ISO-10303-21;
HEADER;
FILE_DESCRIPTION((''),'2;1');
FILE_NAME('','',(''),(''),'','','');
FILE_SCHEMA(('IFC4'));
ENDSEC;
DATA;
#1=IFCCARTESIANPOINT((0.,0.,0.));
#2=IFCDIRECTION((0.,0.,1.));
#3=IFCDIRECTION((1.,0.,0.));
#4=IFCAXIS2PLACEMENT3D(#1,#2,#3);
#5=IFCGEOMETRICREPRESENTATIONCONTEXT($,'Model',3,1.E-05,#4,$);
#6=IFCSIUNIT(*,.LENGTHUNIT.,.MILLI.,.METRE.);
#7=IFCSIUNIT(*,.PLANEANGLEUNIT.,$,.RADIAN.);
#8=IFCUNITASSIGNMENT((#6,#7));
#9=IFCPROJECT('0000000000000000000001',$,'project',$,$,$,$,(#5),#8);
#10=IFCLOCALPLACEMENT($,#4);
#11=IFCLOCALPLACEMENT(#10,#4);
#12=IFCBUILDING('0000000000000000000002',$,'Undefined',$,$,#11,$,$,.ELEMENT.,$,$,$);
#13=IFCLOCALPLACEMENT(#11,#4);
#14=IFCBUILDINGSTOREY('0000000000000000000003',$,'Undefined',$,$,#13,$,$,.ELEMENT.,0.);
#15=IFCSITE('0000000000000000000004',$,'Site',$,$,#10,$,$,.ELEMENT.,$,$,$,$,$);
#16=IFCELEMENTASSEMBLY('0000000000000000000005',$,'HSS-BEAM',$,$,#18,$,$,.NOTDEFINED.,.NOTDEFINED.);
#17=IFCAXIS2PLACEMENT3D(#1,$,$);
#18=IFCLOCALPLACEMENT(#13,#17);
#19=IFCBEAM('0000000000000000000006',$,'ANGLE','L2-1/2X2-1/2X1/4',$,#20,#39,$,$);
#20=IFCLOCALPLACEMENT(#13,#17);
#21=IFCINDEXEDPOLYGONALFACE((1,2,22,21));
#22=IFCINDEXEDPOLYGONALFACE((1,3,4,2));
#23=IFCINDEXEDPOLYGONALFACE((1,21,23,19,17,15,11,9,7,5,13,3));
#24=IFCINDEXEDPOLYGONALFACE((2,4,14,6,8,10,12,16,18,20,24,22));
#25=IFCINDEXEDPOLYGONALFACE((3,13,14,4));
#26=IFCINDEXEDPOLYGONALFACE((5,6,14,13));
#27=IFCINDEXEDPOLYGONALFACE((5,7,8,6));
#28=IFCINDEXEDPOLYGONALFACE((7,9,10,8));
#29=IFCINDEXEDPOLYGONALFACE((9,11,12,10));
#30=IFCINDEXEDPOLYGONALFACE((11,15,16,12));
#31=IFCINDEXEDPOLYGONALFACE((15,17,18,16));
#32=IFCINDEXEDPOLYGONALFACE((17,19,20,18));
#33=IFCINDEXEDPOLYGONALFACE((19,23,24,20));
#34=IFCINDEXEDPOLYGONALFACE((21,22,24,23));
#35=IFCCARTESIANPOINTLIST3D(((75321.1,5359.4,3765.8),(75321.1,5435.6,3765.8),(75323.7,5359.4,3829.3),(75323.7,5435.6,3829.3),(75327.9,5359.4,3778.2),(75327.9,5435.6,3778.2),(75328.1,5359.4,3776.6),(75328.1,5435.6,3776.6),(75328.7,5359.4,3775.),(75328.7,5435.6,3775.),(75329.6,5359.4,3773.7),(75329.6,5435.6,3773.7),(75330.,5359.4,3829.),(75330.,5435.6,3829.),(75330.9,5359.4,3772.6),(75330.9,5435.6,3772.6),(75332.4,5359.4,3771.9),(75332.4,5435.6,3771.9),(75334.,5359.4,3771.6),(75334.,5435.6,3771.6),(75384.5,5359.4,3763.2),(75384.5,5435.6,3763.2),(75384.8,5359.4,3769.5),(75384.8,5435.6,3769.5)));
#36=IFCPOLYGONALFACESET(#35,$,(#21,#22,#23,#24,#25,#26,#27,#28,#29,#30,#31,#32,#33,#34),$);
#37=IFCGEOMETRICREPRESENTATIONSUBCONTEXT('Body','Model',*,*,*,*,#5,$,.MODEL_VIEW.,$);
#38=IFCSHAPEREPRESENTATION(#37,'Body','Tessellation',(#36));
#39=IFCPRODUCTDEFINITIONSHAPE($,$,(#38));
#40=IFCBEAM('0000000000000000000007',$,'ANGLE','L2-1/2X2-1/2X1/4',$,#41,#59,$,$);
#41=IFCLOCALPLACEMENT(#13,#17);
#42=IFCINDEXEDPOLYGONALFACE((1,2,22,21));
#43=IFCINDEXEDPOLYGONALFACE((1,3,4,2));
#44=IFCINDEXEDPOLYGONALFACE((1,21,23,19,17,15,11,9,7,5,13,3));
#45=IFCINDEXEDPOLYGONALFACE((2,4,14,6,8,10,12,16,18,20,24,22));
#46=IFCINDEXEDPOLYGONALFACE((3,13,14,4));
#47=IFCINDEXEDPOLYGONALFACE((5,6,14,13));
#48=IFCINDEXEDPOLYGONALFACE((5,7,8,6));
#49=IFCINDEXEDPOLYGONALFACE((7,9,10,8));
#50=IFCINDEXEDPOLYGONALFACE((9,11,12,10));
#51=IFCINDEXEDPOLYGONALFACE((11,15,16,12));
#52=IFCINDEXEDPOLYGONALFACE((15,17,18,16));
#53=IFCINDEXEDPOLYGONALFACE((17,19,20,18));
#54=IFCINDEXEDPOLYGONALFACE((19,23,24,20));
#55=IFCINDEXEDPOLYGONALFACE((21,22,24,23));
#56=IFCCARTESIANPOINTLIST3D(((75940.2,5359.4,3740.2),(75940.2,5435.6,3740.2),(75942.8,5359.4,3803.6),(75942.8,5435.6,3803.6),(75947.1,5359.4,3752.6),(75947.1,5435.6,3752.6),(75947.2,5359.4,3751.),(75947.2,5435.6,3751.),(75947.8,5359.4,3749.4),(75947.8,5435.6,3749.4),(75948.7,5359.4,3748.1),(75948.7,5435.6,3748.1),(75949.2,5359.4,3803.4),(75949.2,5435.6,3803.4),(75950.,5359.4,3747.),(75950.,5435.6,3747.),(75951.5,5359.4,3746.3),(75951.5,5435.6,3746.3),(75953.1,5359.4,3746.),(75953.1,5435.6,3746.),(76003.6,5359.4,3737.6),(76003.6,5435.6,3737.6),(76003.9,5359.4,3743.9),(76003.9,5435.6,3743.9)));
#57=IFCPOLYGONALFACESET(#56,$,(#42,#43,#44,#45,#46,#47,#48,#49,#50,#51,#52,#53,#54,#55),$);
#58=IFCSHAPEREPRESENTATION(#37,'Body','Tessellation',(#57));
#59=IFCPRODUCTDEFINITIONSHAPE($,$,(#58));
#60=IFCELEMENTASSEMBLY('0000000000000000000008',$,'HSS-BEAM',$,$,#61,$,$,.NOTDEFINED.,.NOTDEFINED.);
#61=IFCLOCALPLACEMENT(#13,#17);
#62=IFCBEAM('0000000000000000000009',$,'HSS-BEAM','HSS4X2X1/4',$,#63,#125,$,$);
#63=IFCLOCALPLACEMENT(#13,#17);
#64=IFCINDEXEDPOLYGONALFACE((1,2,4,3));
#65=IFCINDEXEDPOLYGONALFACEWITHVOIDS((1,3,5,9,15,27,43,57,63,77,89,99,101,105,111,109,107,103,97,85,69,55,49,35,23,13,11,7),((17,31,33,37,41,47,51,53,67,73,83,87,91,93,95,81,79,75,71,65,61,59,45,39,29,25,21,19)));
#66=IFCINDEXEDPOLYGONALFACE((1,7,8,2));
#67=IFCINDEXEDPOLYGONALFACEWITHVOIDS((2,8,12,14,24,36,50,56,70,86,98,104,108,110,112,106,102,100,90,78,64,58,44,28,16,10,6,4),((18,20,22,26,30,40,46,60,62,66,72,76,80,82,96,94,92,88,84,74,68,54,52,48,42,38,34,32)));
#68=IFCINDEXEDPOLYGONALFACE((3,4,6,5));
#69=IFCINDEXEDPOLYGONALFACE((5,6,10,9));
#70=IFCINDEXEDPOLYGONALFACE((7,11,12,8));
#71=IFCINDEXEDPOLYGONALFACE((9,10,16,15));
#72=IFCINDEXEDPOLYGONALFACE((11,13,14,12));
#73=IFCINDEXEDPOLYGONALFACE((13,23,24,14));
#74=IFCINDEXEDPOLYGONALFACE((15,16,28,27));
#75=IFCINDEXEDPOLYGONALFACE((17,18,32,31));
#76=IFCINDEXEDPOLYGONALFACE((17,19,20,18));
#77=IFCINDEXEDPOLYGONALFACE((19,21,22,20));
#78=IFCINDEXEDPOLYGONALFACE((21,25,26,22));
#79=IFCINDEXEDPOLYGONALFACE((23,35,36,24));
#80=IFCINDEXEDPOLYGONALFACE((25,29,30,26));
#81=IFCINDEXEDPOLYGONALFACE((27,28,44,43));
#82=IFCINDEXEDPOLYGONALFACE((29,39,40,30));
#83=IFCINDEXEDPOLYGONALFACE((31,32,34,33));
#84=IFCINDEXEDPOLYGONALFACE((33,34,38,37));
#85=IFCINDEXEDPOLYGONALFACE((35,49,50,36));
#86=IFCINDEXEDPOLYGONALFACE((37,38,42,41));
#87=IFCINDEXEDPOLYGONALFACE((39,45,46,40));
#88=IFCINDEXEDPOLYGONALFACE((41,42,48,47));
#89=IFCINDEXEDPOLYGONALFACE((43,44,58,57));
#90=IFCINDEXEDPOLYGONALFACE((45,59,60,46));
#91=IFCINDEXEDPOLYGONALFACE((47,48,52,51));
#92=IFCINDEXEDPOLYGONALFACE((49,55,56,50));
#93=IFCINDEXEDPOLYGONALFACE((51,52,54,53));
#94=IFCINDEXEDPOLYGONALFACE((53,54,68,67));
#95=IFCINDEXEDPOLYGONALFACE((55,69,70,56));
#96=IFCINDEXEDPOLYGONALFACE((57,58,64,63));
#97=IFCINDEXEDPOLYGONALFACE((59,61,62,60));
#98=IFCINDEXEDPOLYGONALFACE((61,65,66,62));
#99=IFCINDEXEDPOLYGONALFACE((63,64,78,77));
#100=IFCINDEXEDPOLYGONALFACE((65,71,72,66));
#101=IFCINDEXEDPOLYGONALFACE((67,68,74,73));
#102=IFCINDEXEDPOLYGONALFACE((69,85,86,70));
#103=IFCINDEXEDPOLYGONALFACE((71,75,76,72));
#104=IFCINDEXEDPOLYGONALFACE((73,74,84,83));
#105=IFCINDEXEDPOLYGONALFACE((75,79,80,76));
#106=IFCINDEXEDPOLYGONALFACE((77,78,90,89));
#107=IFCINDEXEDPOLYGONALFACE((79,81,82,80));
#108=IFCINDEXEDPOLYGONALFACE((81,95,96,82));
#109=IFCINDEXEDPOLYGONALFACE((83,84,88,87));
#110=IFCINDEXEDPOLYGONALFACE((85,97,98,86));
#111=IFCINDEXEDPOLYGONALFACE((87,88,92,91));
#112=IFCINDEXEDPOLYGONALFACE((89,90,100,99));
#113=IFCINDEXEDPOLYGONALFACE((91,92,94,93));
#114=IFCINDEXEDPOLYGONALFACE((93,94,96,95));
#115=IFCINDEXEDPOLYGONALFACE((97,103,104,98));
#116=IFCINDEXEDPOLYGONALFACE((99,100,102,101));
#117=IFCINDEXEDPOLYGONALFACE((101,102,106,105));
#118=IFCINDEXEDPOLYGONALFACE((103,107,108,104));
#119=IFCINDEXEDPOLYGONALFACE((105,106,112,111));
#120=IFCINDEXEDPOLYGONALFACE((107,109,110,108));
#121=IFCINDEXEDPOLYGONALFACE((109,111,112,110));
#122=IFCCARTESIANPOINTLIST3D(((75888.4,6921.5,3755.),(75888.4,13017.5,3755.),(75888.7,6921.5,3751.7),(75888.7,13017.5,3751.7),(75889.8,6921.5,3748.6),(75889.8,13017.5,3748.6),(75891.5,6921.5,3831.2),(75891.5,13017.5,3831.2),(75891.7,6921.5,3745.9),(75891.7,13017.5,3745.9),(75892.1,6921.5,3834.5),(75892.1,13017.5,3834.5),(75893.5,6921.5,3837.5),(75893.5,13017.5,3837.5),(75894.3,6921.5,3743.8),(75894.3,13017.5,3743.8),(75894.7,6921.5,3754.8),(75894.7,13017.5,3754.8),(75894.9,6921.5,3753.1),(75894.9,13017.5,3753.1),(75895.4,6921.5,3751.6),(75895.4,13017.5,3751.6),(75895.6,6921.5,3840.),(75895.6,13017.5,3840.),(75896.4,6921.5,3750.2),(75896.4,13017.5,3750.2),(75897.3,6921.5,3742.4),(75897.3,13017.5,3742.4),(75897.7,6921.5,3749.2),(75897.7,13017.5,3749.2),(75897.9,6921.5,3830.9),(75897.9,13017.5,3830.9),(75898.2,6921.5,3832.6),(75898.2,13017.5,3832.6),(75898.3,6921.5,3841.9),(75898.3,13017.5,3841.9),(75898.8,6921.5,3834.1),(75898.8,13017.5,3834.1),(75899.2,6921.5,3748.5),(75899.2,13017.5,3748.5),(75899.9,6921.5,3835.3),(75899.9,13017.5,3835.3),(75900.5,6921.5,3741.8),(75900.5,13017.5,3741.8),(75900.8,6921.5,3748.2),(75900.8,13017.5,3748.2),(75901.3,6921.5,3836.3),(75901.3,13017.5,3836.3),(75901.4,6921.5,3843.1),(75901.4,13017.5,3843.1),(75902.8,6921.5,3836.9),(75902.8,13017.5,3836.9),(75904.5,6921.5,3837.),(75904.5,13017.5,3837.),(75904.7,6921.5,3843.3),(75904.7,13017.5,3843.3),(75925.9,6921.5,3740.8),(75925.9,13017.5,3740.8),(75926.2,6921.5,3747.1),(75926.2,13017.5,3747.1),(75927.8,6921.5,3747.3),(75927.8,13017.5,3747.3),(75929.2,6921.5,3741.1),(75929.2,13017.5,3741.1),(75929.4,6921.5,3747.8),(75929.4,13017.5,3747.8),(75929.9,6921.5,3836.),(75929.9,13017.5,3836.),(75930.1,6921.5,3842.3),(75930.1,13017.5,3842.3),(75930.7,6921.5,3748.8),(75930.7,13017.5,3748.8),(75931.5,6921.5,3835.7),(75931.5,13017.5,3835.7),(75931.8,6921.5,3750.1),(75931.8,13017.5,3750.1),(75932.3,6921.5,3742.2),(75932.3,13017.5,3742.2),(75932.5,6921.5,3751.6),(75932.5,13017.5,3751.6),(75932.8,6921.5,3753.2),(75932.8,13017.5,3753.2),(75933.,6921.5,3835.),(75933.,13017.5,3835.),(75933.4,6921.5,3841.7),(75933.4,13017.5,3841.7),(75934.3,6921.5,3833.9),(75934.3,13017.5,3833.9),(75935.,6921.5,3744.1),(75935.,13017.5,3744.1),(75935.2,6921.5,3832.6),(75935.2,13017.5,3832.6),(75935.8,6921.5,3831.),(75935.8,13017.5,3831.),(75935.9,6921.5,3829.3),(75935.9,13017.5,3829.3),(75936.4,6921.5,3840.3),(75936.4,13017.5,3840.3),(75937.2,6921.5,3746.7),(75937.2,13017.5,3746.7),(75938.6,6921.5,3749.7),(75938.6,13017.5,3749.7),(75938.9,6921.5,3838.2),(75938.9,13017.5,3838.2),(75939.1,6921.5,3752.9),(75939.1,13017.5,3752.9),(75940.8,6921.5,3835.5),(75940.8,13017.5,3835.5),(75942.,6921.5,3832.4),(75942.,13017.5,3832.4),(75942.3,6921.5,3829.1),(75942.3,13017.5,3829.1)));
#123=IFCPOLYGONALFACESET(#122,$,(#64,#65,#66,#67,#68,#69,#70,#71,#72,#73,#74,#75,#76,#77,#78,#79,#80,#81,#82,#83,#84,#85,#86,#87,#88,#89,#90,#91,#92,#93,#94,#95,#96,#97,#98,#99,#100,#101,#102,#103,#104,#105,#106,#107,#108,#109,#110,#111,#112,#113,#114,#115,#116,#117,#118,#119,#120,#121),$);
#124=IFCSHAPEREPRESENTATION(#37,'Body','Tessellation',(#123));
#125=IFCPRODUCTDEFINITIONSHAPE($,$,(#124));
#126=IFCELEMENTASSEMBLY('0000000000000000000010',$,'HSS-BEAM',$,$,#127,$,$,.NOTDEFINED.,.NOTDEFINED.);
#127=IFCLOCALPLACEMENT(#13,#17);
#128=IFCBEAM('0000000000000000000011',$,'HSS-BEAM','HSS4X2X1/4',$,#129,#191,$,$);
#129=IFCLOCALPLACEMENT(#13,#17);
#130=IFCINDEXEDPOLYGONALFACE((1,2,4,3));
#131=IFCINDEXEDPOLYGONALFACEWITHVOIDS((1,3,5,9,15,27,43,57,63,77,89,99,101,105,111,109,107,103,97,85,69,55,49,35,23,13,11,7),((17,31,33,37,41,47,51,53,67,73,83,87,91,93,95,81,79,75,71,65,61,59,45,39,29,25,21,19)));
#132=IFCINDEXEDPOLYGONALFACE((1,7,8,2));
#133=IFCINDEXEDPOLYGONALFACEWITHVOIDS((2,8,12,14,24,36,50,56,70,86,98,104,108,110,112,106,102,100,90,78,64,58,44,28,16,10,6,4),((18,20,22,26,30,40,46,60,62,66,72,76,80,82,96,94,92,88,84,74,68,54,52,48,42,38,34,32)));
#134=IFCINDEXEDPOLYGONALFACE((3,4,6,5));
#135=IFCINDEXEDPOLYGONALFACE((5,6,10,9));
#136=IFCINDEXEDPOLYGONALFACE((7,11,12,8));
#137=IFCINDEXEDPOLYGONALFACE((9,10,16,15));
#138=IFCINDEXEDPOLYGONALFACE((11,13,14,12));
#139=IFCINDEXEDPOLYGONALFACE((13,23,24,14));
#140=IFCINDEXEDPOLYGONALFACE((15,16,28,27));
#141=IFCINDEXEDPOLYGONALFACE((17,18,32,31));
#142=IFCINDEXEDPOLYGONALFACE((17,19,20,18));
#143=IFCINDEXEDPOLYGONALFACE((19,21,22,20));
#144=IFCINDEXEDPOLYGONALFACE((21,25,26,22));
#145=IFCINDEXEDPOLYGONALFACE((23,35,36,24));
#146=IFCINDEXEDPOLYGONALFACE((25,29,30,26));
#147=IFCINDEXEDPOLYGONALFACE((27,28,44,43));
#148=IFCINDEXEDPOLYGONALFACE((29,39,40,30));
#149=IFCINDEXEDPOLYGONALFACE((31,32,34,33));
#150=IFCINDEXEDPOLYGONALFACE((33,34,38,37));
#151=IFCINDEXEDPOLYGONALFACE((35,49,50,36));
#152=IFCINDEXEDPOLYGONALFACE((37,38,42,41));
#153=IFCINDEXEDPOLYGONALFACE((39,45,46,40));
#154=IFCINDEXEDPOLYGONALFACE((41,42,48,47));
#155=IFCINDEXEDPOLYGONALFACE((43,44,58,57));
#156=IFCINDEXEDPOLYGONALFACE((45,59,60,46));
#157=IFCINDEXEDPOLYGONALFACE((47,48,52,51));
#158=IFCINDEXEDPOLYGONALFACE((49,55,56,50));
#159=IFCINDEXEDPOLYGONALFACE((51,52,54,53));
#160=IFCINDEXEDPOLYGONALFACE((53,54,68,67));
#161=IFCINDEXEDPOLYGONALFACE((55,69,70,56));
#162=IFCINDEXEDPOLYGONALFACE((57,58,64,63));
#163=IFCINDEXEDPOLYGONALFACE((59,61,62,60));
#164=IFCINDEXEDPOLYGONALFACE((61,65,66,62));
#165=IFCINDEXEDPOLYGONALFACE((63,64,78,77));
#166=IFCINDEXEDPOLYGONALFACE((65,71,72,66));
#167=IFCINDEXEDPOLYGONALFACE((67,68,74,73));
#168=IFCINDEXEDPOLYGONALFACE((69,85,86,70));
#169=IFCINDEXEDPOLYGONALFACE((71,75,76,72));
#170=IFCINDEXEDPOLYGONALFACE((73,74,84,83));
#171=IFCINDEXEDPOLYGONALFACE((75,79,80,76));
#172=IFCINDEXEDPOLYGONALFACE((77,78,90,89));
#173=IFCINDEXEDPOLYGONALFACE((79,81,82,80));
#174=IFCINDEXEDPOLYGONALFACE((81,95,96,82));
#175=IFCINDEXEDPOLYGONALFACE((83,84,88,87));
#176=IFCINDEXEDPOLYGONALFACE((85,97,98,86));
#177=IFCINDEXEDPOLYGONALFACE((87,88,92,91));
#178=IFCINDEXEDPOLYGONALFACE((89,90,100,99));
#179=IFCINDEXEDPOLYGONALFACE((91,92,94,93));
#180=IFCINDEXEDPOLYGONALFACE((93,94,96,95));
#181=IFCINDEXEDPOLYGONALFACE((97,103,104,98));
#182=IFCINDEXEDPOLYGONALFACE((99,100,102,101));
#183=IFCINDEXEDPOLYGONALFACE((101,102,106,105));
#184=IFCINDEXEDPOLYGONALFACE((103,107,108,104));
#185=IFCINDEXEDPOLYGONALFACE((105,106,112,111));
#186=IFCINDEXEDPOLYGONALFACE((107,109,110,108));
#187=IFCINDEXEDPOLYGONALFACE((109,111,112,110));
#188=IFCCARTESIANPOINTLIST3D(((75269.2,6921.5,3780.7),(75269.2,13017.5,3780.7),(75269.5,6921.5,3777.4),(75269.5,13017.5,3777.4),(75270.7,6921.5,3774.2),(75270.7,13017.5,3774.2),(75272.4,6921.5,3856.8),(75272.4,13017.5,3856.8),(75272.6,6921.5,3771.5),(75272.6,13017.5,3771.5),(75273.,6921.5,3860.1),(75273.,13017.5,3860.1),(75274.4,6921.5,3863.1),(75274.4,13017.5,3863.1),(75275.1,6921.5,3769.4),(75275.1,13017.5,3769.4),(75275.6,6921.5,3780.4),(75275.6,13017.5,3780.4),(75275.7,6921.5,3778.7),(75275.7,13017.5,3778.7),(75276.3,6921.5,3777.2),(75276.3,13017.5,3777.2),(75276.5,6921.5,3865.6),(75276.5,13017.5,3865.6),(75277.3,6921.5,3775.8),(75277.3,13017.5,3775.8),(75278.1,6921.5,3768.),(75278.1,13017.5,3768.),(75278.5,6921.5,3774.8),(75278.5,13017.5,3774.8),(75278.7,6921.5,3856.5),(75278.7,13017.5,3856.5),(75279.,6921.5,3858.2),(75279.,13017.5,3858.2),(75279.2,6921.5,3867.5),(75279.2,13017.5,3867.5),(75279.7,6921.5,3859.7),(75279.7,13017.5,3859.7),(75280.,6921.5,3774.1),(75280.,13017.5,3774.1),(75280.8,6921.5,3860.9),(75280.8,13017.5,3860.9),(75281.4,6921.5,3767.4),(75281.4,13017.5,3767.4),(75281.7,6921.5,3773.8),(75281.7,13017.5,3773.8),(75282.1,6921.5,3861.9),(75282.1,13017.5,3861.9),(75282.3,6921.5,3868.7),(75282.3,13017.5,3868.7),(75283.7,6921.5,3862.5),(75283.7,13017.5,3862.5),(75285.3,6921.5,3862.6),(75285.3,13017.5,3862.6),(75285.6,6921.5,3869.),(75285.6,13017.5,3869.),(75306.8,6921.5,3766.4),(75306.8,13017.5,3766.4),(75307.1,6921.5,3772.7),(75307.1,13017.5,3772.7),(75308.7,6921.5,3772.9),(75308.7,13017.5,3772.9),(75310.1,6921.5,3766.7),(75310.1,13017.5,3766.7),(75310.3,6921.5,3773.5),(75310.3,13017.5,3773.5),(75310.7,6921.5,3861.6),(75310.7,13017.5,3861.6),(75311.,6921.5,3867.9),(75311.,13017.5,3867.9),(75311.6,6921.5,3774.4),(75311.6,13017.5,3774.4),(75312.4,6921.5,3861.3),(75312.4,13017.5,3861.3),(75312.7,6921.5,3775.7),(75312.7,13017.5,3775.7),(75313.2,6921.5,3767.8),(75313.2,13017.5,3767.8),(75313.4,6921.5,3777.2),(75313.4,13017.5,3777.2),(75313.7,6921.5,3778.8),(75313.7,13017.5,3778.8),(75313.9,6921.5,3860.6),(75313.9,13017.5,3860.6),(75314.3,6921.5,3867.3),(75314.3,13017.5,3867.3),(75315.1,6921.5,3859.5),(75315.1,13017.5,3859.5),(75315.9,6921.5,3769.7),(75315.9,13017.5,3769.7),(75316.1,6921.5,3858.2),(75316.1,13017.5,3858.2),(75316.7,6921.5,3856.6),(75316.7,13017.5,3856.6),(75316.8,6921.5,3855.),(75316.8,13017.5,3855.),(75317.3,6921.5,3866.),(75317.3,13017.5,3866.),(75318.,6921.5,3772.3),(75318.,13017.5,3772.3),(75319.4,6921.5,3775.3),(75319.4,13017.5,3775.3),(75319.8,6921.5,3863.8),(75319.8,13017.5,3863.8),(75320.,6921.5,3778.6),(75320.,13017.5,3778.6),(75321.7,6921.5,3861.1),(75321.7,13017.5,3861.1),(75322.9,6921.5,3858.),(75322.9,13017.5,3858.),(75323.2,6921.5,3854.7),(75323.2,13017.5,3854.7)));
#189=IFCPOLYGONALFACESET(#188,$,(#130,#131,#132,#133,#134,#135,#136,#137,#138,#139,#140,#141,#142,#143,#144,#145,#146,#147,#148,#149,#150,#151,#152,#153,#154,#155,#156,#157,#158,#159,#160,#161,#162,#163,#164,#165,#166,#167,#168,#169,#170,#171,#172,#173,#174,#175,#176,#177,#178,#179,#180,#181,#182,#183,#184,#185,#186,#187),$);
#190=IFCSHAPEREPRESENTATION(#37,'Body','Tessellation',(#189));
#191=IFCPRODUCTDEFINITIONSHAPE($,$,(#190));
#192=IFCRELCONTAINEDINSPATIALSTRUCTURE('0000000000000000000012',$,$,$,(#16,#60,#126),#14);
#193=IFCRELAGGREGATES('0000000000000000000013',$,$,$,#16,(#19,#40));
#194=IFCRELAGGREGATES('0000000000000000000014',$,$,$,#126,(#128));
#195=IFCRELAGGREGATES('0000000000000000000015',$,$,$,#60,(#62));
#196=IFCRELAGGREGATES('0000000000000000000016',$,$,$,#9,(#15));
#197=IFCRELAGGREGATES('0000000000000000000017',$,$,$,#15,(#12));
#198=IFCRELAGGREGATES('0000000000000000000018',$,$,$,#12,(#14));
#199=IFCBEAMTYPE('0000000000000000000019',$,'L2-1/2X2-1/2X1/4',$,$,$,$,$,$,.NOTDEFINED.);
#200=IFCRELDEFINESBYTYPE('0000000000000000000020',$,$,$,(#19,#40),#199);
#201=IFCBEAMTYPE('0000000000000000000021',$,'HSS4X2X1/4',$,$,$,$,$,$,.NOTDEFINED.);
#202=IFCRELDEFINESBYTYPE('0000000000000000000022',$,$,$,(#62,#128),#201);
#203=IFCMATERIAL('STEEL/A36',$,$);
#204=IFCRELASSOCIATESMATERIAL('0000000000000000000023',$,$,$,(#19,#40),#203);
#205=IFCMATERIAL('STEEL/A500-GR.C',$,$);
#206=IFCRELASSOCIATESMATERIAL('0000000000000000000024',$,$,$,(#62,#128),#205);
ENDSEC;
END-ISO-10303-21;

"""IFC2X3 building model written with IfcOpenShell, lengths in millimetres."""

from ifc_helpers import new_model, si_unit, frame, origin_with_axes, origin_2d_with_axis, place, context, subcontext, project, spatial, hollow_rectangle, l_section, extrude, material, type_object, element, aggregate, save


model = new_model("IFC2X3")

# Units and contexts
model_context = context("Model", 3, precision=1e-05, world=origin_with_axes())
body_context = subcontext(model_context, "Body", "Model", "MODEL_VIEW")
ifc_project = project(units=[si_unit("LENGTHUNIT", "METRE", prefix="MILLI"), si_unit("PLANEANGLEUNIT", "RADIAN")], contexts=[model_context])

# Site, building, storey
site_placement = place(None, origin_with_axes())
site = spatial("IfcSite", under=ifc_project, at=site_placement, Name="Site", CompositionType="ELEMENT")
building_placement = place(site_placement, origin_with_axes())
building = spatial("IfcBuilding", under=site, at=building_placement, Name="Undefined", CompositionType="ELEMENT")
storey_placement = place(building_placement, origin_with_axes())
storey = spatial("IfcBuildingStorey", under=building, at=storey_placement, Name="Undefined", CompositionType="ELEMENT", Elevation=0.0)

# Element assembly, beams
ifc_material_1 = material(Name="STEEL/A36")
beam_type_1 = type_object("IfcBeamType", Name="L2-1/2X2-1/2X1/4", PredefinedType="NOTDEFINED")
assembly_1_placement = place(storey_placement, origin_with_axes())
assembly_1 = element("IfcElementAssembly", 1, at=assembly_1_placement, inside=storey, Name="HSS-BEAM", AssemblyPlace="NOTDEFINED", PredefinedType="NOTDEFINED")
beam_1_placement = place(assembly_1_placement, frame((75354.1, 5435.6, 3796.2), z_axis=(0.999145, 0.0, -0.041337), x_axis=(0.0, -1.0, 0.0)))
beam_1 = element("IfcBeam", 2, at=beam_1_placement, type_object=beam_type_1, material=ifc_material_1, Name="ANGLE", Description="L2-1/2X2-1/2X1/4", context=body_context, shape_type="SweptSolid", body=[
    extrude(l_section(Depth=63.5, Width=63.5, Thickness=6.3, FilletRadius=6.3, at=origin_2d_with_axis()), frame((76.2, 0.0, 0.0), z_axis=(-1.0, 0.0, 0.0), x_axis=(0.0, -1.0, 0.0)), (0.0, 0.0, 1.0), 76.2),
])
beam_2_placement = place(assembly_1_placement, frame((75973.2, 5435.6, 3770.6), z_axis=(0.999145, 0.0, -0.041337), x_axis=(0.0, -1.0, 0.0)))
beam_2 = element("IfcBeam", 3, at=beam_2_placement, type_object=beam_type_1, material=ifc_material_1, Name="ANGLE", Description="L2-1/2X2-1/2X1/4", context=body_context, shape_type="SweptSolid", body=[
    extrude(l_section(Depth=63.5, Width=63.5, Thickness=6.3, FilletRadius=6.3, at=origin_2d_with_axis()), frame((76.2, 0.0, 0.0), z_axis=(-1.0, 0.0, 0.0), x_axis=(0.0, -1.0, 0.0)), (0.0, 0.0, 1.0), 76.2),
])
aggregate(assembly_1, [beam_1, beam_2])

# Element assemblies, beams
assembly_2_placement = place(storey_placement, origin_with_axes())
assembly_2 = element("IfcElementAssembly", 4, at=assembly_2_placement, inside=storey, Name="HSS-BEAM", AssemblyPlace="NOTDEFINED", PredefinedType="NOTDEFINED")
ifc_material_2 = material(Name="STEEL/A500-GR.C")
beam_type_2 = type_object("IfcBeamType", Name="HSS4X2X1/4", PredefinedType="NOTDEFINED")
beam_3_placement = place(assembly_2_placement, frame((75915.3, 6921.5, 3792.1), z_axis=(0.041337, 0.0, 0.999145), x_axis=(0.0, 1.0, 0.0)))
beam_3 = element("IfcBeam", 5, at=beam_3_placement, type_object=beam_type_2, material=ifc_material_2, Name="HSS-BEAM", Description="HSS4X2X1/4", context=body_context, shape_type="SweptSolid", body=[
    extrude(hollow_rectangle(XDim=50.8, YDim=101.6, WallThickness=6.3, InnerFilletRadius=6.3, OuterFilletRadius=12.7, at=origin_2d_with_axis()), frame((6096.0, 0.0, 0.0), z_axis=(-1.0, 0.0, 0.0), x_axis=(0.0, -1.0, 0.0)), (0.0, 0.0, 1.0), 6096.0),
])
assembly_3_placement = place(storey_placement, origin_with_axes())
assembly_3 = element("IfcElementAssembly", 6, at=assembly_3_placement, inside=storey, Name="HSS-BEAM", AssemblyPlace="NOTDEFINED", PredefinedType="NOTDEFINED")
beam_4_placement = place(assembly_3_placement, frame((75296.2, 6921.5, 3817.7), z_axis=(0.041337, 0.0, 0.999145), x_axis=(0.0, 1.0, 0.0)))
beam_4 = element("IfcBeam", 7, at=beam_4_placement, type_object=beam_type_2, material=ifc_material_2, Name="HSS-BEAM", Description="HSS4X2X1/4", context=body_context, shape_type="SweptSolid", body=[
    extrude(hollow_rectangle(XDim=50.8, YDim=101.6, WallThickness=6.3, InnerFilletRadius=6.3, OuterFilletRadius=12.7, at=origin_2d_with_axis()), frame((6096.0, 0.0, 0.0), z_axis=(-1.0, 0.0, 0.0), x_axis=(0.0, -1.0, 0.0)), (0.0, 0.0, 1.0), 6096.0),
])

aggregate(assembly_3, [beam_4])

aggregate(assembly_2, [beam_3])

save(model, "model.ifc")
